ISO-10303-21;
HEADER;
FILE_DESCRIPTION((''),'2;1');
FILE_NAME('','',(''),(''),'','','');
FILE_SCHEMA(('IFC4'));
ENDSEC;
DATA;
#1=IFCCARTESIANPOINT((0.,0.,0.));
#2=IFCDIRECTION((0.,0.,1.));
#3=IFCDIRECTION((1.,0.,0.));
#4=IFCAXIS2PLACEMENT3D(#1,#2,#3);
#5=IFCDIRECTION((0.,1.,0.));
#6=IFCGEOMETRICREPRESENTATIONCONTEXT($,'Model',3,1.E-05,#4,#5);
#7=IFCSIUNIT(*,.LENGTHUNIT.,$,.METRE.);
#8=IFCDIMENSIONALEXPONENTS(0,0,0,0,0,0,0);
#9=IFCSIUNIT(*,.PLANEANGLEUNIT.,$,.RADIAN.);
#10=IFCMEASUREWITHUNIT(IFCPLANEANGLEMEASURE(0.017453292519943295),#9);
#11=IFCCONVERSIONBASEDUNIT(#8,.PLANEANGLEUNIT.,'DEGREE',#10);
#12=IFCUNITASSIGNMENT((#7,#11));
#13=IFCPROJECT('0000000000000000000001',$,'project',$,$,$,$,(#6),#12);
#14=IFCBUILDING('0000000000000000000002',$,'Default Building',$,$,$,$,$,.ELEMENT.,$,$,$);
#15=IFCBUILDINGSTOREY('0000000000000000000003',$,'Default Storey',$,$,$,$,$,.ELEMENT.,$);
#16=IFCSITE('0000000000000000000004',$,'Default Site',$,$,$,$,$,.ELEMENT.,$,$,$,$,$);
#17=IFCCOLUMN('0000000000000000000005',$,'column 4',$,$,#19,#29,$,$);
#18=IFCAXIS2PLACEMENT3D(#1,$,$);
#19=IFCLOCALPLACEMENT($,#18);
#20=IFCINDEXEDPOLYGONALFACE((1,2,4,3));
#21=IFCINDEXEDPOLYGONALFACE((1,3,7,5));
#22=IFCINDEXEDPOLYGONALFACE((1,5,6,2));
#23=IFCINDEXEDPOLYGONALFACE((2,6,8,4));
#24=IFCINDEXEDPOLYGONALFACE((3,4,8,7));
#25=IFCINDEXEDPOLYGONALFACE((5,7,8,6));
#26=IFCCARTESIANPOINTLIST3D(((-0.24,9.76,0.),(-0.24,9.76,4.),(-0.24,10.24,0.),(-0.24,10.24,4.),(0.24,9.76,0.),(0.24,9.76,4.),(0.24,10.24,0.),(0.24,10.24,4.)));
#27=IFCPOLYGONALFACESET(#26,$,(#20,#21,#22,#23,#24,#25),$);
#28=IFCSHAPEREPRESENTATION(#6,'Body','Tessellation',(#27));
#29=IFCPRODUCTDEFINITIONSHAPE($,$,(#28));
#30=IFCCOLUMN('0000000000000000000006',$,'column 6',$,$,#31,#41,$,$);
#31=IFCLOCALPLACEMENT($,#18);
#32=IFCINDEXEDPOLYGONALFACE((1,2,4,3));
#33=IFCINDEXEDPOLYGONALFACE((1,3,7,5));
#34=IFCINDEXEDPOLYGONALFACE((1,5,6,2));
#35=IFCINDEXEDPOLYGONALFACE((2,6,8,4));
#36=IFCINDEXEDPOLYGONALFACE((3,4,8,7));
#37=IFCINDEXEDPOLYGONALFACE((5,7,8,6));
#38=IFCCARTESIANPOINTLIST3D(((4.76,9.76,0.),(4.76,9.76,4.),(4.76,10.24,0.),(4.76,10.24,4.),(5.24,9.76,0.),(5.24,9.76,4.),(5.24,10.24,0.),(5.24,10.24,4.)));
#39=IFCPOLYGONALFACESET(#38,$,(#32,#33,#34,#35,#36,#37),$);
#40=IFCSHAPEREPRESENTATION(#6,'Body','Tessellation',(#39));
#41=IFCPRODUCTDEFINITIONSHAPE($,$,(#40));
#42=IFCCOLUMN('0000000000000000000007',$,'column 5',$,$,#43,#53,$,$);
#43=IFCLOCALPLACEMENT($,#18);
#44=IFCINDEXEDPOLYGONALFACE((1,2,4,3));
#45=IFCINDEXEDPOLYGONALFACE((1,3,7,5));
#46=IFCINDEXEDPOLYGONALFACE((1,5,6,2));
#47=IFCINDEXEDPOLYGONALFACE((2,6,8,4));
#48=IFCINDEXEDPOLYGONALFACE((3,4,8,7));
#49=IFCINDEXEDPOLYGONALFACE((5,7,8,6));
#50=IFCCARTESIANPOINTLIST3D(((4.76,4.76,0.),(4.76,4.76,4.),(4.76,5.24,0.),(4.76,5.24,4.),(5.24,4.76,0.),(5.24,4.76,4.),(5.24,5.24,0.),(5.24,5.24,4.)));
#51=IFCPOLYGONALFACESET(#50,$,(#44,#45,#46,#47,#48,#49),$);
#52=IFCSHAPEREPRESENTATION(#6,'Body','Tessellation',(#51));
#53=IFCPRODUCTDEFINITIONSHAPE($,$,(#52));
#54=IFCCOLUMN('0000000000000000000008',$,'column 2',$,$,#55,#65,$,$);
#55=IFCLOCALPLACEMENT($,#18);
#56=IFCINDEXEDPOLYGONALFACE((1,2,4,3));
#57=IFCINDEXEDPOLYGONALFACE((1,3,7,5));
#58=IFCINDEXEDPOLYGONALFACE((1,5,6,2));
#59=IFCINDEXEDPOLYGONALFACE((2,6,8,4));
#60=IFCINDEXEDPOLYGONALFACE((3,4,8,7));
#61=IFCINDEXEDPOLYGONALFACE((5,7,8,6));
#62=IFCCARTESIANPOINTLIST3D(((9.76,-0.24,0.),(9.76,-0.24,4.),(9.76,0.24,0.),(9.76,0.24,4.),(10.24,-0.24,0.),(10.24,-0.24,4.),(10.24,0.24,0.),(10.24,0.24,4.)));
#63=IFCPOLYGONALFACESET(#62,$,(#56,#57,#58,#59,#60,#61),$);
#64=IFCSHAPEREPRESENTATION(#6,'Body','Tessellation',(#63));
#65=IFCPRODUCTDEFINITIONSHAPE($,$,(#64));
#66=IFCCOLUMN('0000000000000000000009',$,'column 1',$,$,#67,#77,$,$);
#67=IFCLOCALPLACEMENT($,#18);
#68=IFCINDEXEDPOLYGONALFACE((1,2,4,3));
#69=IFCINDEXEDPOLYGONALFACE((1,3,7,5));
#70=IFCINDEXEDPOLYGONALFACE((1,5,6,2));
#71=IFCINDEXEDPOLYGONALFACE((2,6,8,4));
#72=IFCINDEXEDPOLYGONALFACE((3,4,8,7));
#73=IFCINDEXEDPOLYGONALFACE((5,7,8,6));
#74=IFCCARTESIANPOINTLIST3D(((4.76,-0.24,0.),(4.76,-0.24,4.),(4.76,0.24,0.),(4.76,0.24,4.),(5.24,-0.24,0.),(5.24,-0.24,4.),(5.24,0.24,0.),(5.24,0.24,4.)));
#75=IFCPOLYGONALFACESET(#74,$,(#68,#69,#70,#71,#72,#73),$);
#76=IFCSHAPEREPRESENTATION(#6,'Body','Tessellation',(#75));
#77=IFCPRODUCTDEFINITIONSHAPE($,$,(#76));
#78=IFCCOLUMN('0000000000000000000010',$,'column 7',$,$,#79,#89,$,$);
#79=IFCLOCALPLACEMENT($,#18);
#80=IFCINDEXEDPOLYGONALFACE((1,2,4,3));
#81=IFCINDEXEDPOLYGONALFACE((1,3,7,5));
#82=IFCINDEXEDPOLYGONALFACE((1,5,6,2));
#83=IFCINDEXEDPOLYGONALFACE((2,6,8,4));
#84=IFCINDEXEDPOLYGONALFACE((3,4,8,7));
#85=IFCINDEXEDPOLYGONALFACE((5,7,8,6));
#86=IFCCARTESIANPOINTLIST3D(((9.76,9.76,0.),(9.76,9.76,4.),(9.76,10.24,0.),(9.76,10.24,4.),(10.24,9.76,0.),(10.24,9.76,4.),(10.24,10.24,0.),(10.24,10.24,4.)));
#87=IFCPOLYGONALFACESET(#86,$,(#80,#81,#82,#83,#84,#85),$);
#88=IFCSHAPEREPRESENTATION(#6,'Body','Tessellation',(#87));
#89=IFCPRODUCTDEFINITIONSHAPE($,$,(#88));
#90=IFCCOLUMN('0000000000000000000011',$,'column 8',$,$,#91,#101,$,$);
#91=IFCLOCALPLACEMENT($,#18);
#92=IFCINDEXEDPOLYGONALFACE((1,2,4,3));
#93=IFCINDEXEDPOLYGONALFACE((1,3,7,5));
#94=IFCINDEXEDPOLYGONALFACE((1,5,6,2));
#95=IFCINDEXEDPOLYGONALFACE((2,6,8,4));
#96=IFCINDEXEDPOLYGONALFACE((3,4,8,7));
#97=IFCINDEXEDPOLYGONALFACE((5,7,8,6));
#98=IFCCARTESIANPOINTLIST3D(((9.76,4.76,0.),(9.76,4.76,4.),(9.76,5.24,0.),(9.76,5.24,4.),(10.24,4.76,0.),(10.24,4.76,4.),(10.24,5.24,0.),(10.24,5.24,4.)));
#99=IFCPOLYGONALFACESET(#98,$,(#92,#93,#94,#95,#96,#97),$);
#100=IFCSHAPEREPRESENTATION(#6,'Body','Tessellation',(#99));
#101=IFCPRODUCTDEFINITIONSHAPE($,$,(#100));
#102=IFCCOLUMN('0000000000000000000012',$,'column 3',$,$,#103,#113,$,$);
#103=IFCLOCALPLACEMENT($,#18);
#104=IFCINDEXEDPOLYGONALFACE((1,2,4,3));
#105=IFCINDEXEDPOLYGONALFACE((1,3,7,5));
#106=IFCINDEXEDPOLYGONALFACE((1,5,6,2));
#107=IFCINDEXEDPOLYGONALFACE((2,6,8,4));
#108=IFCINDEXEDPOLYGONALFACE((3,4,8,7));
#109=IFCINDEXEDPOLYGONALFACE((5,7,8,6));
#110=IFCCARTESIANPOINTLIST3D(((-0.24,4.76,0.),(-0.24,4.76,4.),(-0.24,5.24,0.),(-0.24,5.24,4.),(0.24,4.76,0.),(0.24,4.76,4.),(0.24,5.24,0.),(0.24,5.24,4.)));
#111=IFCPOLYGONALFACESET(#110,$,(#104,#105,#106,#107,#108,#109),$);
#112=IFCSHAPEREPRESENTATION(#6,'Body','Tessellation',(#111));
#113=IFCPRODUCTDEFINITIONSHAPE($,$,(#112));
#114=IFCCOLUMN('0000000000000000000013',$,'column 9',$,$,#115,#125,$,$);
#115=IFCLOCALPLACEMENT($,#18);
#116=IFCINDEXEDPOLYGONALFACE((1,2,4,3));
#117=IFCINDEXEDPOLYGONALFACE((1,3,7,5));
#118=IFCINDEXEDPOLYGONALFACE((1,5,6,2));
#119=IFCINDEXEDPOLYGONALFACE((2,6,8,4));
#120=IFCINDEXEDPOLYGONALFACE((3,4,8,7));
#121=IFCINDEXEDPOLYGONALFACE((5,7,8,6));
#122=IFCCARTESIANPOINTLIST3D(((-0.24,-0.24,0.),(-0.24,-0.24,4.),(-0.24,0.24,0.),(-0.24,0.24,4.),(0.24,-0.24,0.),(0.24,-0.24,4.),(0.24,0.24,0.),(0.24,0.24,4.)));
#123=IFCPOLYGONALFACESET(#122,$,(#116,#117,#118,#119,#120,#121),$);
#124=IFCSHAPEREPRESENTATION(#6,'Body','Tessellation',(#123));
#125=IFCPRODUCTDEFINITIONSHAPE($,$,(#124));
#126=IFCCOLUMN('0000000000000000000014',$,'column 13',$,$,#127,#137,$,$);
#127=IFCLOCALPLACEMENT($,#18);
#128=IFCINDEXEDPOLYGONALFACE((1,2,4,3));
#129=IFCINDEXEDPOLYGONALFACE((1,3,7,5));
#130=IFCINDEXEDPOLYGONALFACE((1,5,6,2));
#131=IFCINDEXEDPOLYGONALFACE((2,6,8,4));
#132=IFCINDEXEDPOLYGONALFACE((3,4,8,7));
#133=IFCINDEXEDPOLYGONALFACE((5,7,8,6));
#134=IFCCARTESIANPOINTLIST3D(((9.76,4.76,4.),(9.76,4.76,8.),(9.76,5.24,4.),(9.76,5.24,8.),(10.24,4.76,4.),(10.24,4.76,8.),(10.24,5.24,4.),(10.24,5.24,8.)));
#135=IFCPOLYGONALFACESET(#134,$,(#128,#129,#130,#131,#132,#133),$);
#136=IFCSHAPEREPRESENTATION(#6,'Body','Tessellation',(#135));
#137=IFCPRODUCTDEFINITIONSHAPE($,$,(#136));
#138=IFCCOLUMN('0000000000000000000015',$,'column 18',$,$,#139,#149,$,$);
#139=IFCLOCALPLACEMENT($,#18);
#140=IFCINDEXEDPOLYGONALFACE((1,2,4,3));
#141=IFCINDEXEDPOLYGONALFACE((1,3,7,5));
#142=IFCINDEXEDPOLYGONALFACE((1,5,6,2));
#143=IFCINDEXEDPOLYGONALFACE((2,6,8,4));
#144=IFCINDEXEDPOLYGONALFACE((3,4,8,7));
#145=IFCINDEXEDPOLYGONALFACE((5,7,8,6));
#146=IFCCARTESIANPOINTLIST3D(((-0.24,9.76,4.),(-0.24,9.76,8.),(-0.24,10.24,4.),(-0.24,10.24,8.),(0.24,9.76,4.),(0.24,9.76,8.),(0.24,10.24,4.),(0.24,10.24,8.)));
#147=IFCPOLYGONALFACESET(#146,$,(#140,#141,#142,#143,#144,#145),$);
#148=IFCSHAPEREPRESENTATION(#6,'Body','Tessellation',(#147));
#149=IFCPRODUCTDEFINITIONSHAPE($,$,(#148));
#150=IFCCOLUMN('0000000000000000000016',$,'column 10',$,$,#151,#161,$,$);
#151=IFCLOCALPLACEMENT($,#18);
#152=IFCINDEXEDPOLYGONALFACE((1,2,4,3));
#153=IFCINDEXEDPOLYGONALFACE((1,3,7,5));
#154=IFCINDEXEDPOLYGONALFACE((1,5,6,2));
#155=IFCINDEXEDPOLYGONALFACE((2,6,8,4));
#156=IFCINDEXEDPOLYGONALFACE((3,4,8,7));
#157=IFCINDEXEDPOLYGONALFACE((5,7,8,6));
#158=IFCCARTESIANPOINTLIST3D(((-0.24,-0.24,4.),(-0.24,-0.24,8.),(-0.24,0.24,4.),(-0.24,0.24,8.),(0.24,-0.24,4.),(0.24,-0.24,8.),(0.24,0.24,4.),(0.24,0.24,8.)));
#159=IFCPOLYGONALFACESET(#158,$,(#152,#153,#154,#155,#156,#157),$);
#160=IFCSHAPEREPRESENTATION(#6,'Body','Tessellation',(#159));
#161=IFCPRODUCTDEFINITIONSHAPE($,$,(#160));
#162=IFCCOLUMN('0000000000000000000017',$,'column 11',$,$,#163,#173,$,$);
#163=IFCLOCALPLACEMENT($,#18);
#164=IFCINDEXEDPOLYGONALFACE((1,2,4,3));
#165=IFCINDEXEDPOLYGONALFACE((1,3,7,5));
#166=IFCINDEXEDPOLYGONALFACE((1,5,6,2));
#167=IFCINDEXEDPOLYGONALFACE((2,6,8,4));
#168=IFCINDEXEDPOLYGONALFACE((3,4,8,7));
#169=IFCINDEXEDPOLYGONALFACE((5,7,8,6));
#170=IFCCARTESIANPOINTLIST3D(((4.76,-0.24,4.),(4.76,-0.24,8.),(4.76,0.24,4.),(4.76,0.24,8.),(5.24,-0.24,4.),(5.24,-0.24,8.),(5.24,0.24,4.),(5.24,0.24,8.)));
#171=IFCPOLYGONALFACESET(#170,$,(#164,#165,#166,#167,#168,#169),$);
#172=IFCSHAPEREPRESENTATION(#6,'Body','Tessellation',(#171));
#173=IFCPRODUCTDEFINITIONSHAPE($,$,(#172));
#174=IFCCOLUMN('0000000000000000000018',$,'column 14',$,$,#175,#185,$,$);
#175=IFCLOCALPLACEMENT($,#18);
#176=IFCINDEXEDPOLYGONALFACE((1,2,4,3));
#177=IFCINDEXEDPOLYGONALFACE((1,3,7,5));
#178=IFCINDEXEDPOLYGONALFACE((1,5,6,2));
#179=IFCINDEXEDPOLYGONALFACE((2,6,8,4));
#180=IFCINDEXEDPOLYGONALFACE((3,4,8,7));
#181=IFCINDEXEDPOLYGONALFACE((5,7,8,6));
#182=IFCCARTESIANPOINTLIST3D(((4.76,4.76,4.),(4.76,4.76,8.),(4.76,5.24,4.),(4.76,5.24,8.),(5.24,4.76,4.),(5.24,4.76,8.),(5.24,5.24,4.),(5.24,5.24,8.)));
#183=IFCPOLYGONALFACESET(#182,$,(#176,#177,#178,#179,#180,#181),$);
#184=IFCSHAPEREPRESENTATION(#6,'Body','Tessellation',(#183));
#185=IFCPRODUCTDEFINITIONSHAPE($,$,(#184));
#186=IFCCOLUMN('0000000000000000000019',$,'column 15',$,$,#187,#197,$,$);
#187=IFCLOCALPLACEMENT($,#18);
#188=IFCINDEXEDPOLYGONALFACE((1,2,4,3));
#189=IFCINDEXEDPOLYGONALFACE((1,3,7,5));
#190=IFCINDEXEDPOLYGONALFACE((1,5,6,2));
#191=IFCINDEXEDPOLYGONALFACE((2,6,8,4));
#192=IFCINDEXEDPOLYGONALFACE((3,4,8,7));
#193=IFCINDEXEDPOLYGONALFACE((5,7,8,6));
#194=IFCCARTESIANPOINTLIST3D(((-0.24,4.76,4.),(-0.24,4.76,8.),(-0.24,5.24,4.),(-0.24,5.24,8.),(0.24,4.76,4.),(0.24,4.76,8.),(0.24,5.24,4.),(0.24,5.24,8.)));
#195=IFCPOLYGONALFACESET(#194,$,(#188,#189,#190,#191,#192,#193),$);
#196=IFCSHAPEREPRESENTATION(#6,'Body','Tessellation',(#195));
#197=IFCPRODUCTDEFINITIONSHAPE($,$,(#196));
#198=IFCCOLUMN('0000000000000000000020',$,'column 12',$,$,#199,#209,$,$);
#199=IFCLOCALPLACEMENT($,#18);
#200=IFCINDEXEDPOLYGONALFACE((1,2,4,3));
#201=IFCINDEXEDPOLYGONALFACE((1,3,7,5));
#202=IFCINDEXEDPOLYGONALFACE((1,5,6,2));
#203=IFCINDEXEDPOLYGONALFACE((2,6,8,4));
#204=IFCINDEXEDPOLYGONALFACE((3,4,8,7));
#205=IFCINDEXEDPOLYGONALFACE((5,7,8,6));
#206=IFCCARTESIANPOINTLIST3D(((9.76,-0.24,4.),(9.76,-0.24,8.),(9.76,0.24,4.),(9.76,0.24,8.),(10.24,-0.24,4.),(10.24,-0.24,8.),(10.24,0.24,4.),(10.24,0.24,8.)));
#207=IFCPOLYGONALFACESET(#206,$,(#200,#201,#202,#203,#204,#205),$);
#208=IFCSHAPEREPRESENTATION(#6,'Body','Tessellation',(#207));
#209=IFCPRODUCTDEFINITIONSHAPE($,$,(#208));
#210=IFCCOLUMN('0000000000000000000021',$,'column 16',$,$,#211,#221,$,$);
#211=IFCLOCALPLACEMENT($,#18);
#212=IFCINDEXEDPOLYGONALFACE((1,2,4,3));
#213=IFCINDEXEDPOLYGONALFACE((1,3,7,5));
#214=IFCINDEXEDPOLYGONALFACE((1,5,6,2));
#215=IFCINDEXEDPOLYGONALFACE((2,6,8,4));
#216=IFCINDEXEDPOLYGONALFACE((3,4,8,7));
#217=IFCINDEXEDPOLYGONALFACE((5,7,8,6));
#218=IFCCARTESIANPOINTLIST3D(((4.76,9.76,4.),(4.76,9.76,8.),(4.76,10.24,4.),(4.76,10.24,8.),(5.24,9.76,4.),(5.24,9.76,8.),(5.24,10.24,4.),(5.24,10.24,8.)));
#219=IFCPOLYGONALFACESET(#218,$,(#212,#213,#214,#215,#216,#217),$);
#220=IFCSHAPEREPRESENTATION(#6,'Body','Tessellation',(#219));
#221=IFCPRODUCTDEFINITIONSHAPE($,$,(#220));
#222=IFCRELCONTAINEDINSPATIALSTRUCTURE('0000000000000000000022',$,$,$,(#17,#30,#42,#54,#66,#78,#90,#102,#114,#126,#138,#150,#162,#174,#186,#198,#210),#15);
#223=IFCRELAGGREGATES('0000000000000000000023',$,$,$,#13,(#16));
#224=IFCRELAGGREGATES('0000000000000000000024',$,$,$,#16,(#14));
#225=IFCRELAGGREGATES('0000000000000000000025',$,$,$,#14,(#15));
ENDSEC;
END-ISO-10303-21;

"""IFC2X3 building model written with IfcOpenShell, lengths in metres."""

from ifc_helpers import new_model, entity, si_unit, converted_unit, direction, frame, origin_with_axes, place, context, project, spatial, polyline, outline, extrude, element, save


model = new_model("IFC2X3")

# Units and contexts
model_context = context("Model", 3, precision=1e-05, world=origin_with_axes(), true_north=direction((0.0, 1.0, 0.0)))
ifc_project = project(units=[si_unit("LENGTHUNIT", "METRE"), converted_unit("PLANEANGLEUNIT", "DEGREE", entity("IfcPlaneAngleMeasure", 0.017453292519943295), si_unit("PLANEANGLEUNIT", "RADIAN"), dimensions=[0, 0, 0, 0, 0, 0, 0])], contexts=[model_context])

# Site, building, storey
site = spatial("IfcSite", under=ifc_project, Name="Default Site", CompositionType="ELEMENT")
building = spatial("IfcBuilding", under=site, Name="Default Building", CompositionType="ELEMENT")
storey = spatial("IfcBuildingStorey", under=building, Name="Default Storey", CompositionType="ELEMENT")

# Columns
placement = place(None, origin_with_axes())
element("IfcColumn", 1, at=placement, inside=storey, Name="column 4", context=model_context, shape_type="SweptSolid", body=[
    extrude(outline(polyline([(-0.24, -0.24), (0.24, -0.24), (0.24, 0.24), (-0.24, 0.24), (-0.24, -0.24)])), frame((0.0, 10.0, 0.0), z_axis=(0.0, 0.0, 1.0), x_axis=(1.0, 0.0, 0.0)), (0.0, 0.0, 1.0), 4.0),
])
element("IfcColumn", 2, at=placement, inside=storey, Name="column 6", context=model_context, shape_type="SweptSolid", body=[
    extrude(outline(polyline([(-0.24, -0.24), (0.24, -0.24), (0.24, 0.24), (-0.24, 0.24), (-0.24, -0.24)])), frame((5.0, 10.0, 0.0), z_axis=(0.0, 0.0, 1.0), x_axis=(1.0, 0.0, 0.0)), (0.0, 0.0, 1.0), 4.0),
])
element("IfcColumn", 3, at=placement, inside=storey, Name="column 5", context=model_context, shape_type="SweptSolid", body=[
    extrude(outline(polyline([(-0.24, -0.24), (0.24, -0.24), (0.24, 0.24), (-0.24, 0.24), (-0.24, -0.24)])), frame((5.0, 5.0, 0.0), z_axis=(0.0, 0.0, 1.0), x_axis=(1.0, 0.0, 0.0)), (0.0, 0.0, 1.0), 4.0),
])
element("IfcColumn", 4, at=placement, inside=storey, Name="column 2", context=model_context, shape_type="SweptSolid", body=[
    extrude(outline(polyline([(-0.24, -0.24), (0.24, -0.24), (0.24, 0.24), (-0.24, 0.24), (-0.24, -0.24)])), frame((10.0, 0.0, 0.0), z_axis=(0.0, 0.0, 1.0), x_axis=(1.0, 0.0, 0.0)), (0.0, 0.0, 1.0), 4.0),
])
element("IfcColumn", 5, at=placement, inside=storey, Name="column 1", context=model_context, shape_type="SweptSolid", body=[
    extrude(outline(polyline([(-0.24, -0.24), (0.24, -0.24), (0.24, 0.24), (-0.24, 0.24), (-0.24, -0.24)])), frame((5.0, 0.0, 0.0), z_axis=(0.0, 0.0, 1.0), x_axis=(1.0, 0.0, 0.0)), (0.0, 0.0, 1.0), 4.0),
])
element("IfcColumn", 6, at=placement, inside=storey, Name="column 7", context=model_context, shape_type="SweptSolid", body=[
    extrude(outline(polyline([(-0.24, -0.24), (0.24, -0.24), (0.24, 0.24), (-0.24, 0.24), (-0.24, -0.24)])), frame((10.0, 10.0, 0.0), z_axis=(0.0, 0.0, 1.0), x_axis=(1.0, 0.0, 0.0)), (0.0, 0.0, 1.0), 4.0),
])
element("IfcColumn", 7, at=placement, inside=storey, Name="column 8", context=model_context, shape_type="SweptSolid", body=[
    extrude(outline(polyline([(-0.24, -0.24), (0.24, -0.24), (0.24, 0.24), (-0.24, 0.24), (-0.24, -0.24)])), frame((10.0, 5.0, 0.0), z_axis=(0.0, 0.0, 1.0), x_axis=(1.0, 0.0, 0.0)), (0.0, 0.0, 1.0), 4.0),
])
element("IfcColumn", 8, at=placement, inside=storey, Name="column 3", context=model_context, shape_type="SweptSolid", body=[
    extrude(outline(polyline([(-0.24, -0.24), (0.24, -0.24), (0.24, 0.24), (-0.24, 0.24), (-0.24, -0.24)])), frame((0.0, 5.0, 0.0), z_axis=(0.0, 0.0, 1.0), x_axis=(1.0, 0.0, 0.0)), (0.0, 0.0, 1.0), 4.0),
])
element("IfcColumn", 9, at=placement, inside=storey, Name="column 9", context=model_context, shape_type="SweptSolid", body=[
    extrude(outline(polyline([(-0.24, -0.24), (0.24, -0.24), (0.24, 0.24), (-0.24, 0.24), (-0.24, -0.24)])), frame((0.0, 0.0, 0.0), z_axis=(0.0, 0.0, 1.0), x_axis=(1.0, 0.0, 0.0)), (0.0, 0.0, 1.0), 4.0),
])
element("IfcColumn", 10, at=placement, inside=storey, Name="column 13", context=model_context, shape_type="SweptSolid", body=[
    extrude(outline(polyline([(-0.24, -0.24), (0.24, -0.24), (0.24, 0.24), (-0.24, 0.24), (-0.24, -0.24)])), frame((10.0, 5.0, 4.0), z_axis=(0.0, 0.0, 1.0), x_axis=(1.0, 0.0, 0.0)), (0.0, 0.0, 1.0), 4.0),
])
element("IfcColumn", 11, at=placement, inside=storey, Name="column 18", context=model_context, shape_type="SweptSolid", body=[
    extrude(outline(polyline([(-0.24, -0.24), (0.24, -0.24), (0.24, 0.24), (-0.24, 0.24), (-0.24, -0.24)])), frame((0.0, 10.0, 4.0), z_axis=(0.0, 0.0, 1.0), x_axis=(1.0, 0.0, 0.0)), (0.0, 0.0, 1.0), 4.0),
])
element("IfcColumn", 12, at=placement, inside=storey, Name="column 10", context=model_context, shape_type="SweptSolid", body=[
    extrude(outline(polyline([(-0.24, -0.24), (0.24, -0.24), (0.24, 0.24), (-0.24, 0.24), (-0.24, -0.24)])), frame((0.0, 0.0, 4.0), z_axis=(0.0, 0.0, 1.0), x_axis=(1.0, 0.0, 0.0)), (0.0, 0.0, 1.0), 4.0),
])
element("IfcColumn", 13, at=placement, inside=storey, Name="column 11", context=model_context, shape_type="SweptSolid", body=[
    extrude(outline(polyline([(-0.24, -0.24), (0.24, -0.24), (0.24, 0.24), (-0.24, 0.24), (-0.24, -0.24)])), frame((5.0, 0.0, 4.0), z_axis=(0.0, 0.0, 1.0), x_axis=(1.0, 0.0, 0.0)), (0.0, 0.0, 1.0), 4.0),
])
element("IfcColumn", 14, at=placement, inside=storey, Name="column 14", context=model_context, shape_type="SweptSolid", body=[
    extrude(outline(polyline([(-0.24, -0.24), (0.24, -0.24), (0.24, 0.24), (-0.24, 0.24), (-0.24, -0.24)])), frame((5.0, 5.0, 4.0), z_axis=(0.0, 0.0, 1.0), x_axis=(1.0, 0.0, 0.0)), (0.0, 0.0, 1.0), 4.0),
])
element("IfcColumn", 15, at=placement, inside=storey, Name="column 15", context=model_context, shape_type="SweptSolid", body=[
    extrude(outline(polyline([(-0.24, -0.24), (0.24, -0.24), (0.24, 0.24), (-0.24, 0.24), (-0.24, -0.24)])), frame((0.0, 5.0, 4.0), z_axis=(0.0, 0.0, 1.0), x_axis=(1.0, 0.0, 0.0)), (0.0, 0.0, 1.0), 4.0),
])
element("IfcColumn", 16, at=placement, inside=storey, Name="column 12", context=model_context, shape_type="SweptSolid", body=[
    extrude(outline(polyline([(-0.24, -0.24), (0.24, -0.24), (0.24, 0.24), (-0.24, 0.24), (-0.24, -0.24)])), frame((10.0, 0.0, 4.0), z_axis=(0.0, 0.0, 1.0), x_axis=(1.0, 0.0, 0.0)), (0.0, 0.0, 1.0), 4.0),
])
element("IfcColumn", 17, at=placement, inside=storey, Name="column 16", context=model_context, shape_type="SweptSolid", body=[
    extrude(outline(polyline([(-0.24, -0.24), (0.24, -0.24), (0.24, 0.24), (-0.24, 0.24), (-0.24, -0.24)])), frame((5.0, 10.0, 4.0), z_axis=(0.0, 0.0, 1.0), x_axis=(1.0, 0.0, 0.0)), (0.0, 0.0, 1.0), 4.0),
])

save(model, "model.ifc")
